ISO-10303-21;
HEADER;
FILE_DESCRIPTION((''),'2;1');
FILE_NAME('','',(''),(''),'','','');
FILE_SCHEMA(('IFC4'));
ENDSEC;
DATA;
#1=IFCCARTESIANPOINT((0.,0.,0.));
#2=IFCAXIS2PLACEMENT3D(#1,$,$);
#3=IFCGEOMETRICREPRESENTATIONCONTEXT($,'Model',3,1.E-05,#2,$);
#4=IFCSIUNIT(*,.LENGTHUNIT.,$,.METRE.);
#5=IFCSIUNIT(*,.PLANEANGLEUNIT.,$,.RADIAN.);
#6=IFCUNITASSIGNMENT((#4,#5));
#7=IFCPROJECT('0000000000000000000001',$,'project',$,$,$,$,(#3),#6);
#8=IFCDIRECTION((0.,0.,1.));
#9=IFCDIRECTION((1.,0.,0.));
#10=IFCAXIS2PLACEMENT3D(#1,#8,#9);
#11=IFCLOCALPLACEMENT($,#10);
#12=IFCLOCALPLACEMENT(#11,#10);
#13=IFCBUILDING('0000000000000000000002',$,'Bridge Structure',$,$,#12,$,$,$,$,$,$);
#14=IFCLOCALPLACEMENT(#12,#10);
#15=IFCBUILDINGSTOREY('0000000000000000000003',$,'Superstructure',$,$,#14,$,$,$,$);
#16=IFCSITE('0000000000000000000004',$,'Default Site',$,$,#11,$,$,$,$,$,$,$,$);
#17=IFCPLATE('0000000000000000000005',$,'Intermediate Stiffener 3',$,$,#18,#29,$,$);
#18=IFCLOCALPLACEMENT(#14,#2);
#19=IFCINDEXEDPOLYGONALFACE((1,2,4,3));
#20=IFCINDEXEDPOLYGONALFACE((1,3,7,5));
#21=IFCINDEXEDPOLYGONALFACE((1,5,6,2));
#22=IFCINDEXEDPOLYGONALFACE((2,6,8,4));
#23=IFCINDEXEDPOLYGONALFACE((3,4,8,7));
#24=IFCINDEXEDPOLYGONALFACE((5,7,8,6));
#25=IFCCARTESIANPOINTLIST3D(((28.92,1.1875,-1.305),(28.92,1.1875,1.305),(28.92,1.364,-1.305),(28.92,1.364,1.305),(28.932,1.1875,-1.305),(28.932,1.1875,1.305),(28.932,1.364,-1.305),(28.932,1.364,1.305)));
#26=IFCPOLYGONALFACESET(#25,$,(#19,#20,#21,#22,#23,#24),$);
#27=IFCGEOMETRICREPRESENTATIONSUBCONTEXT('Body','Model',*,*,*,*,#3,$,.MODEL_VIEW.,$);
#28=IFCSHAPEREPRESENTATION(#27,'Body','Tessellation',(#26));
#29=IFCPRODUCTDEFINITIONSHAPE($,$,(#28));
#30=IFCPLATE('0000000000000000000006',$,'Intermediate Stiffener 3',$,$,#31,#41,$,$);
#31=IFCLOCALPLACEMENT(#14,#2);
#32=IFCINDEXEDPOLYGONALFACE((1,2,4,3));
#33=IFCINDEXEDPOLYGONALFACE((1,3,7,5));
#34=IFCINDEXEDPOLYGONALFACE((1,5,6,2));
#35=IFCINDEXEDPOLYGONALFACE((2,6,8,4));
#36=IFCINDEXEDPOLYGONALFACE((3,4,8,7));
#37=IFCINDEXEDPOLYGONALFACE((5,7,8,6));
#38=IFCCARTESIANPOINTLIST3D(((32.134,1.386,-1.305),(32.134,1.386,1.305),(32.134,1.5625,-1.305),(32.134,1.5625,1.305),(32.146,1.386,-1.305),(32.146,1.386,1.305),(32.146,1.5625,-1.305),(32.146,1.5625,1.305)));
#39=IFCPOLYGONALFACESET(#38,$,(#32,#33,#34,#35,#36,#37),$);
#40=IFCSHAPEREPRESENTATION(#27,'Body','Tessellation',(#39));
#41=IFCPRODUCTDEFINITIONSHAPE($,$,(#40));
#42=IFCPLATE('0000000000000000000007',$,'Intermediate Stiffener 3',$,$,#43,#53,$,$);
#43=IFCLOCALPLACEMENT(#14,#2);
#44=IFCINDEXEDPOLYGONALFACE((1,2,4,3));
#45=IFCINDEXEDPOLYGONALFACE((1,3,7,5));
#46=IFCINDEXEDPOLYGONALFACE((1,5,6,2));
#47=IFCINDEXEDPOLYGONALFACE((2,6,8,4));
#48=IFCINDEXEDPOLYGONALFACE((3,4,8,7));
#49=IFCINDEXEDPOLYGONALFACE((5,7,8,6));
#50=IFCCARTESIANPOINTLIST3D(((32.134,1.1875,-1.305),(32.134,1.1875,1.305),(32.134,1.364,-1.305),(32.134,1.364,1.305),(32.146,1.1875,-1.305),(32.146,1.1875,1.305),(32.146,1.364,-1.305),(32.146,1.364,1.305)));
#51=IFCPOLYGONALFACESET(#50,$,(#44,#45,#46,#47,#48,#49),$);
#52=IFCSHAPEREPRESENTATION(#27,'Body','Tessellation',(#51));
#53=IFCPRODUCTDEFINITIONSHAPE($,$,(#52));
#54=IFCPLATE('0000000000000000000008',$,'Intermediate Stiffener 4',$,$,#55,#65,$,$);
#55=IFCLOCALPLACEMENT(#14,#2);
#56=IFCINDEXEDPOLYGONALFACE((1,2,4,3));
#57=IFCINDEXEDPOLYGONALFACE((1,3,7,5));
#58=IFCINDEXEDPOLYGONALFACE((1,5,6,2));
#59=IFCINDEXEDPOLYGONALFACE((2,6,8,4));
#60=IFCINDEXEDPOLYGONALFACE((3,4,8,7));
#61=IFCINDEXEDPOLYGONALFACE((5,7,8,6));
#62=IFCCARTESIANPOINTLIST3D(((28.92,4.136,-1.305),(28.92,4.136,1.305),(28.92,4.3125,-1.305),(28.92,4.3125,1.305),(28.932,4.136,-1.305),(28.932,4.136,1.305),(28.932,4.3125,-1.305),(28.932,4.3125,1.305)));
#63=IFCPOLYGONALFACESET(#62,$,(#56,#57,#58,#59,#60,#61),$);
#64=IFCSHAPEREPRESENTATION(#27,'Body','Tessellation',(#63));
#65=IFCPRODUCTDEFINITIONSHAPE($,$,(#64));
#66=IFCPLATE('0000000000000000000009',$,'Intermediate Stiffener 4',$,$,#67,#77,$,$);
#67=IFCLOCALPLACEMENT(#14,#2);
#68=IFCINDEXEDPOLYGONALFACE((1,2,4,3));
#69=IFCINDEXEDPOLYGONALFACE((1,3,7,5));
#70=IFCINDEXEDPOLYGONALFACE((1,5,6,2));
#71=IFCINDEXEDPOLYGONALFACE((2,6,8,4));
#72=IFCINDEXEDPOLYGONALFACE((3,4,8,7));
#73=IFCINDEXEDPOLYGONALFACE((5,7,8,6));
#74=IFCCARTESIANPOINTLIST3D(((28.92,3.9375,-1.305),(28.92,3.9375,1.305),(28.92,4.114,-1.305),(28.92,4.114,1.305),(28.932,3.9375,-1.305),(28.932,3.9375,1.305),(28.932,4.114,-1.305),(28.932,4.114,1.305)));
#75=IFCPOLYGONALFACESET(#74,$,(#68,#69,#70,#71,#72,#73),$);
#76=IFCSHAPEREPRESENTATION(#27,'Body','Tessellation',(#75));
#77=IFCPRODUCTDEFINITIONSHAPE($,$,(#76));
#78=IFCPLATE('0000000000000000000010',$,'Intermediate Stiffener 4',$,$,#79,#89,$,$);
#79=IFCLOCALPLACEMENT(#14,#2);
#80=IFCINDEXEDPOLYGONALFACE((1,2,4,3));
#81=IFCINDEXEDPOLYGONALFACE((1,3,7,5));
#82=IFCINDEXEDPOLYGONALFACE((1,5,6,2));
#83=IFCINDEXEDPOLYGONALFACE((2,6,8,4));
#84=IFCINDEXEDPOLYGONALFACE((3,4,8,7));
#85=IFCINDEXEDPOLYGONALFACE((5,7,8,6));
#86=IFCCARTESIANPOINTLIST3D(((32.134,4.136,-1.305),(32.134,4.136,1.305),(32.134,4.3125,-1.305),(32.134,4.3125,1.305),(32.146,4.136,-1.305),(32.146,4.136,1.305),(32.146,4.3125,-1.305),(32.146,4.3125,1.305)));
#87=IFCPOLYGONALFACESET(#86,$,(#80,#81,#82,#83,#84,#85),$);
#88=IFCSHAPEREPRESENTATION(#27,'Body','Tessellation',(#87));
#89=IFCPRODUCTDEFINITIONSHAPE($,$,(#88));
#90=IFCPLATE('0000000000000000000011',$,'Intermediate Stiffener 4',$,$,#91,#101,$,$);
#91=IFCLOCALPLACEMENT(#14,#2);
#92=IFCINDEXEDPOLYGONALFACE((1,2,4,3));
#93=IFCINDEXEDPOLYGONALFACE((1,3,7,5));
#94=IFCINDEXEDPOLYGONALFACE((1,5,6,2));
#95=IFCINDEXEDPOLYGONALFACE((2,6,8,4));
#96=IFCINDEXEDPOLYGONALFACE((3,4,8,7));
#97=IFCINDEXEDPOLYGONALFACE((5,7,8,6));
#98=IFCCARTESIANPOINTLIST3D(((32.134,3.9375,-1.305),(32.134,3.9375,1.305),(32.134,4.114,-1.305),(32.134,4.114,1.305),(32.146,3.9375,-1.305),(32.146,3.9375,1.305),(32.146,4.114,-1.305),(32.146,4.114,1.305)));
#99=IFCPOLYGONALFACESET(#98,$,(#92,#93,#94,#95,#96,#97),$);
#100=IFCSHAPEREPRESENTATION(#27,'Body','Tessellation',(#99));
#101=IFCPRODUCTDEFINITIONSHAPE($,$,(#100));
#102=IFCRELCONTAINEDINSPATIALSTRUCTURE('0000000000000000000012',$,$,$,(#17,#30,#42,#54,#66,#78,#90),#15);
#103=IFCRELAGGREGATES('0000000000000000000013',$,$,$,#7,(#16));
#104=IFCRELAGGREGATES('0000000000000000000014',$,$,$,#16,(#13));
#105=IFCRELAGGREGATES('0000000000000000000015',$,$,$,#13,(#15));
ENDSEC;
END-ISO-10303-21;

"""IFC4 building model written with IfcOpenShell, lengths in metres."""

from ifc_helpers import new_model, si_unit, frame, origin, origin_with_axes, origin_2d_with_axis, place, context, subcontext, project, spatial, rectangle, extrude, element, save


model = new_model("IFC4")

# Units and contexts
model_context = context("Model", 3, precision=1e-05, world=origin())
body_context = subcontext(model_context, "Body", "Model", "MODEL_VIEW")
ifc_project = project(units=[si_unit("LENGTHUNIT", "METRE"), si_unit("PLANEANGLEUNIT", "RADIAN")], contexts=[model_context])

# Site, building, storey
site_placement = place(None, origin_with_axes())
site = spatial("IfcSite", under=ifc_project, at=site_placement, Name="Default Site")
building_placement = place(site_placement, origin_with_axes())
building = spatial("IfcBuilding", under=site, at=building_placement, Name="Bridge Structure")
storey_placement = place(building_placement, origin_with_axes())
storey = spatial("IfcBuildingStorey", under=building, at=storey_placement, Name="Superstructure")

# Plates
for number, where, z_axis, x_axis, name in (
    (1, (28.926, 1.2757, -1.305), (0.0, 0.0, 1.0), (1.0, 0.0, 0.0), "Intermediate Stiffener 3"),
    (2, (32.14, 1.4743, -1.305), (0.0, 0.0, 1.0), (1.0, 0.0, 0.0), "Intermediate Stiffener 3"),
    (3, (32.14, 1.2757, -1.305), (0.0, 0.0, 1.0), (1.0, 0.0, 0.0), "Intermediate Stiffener 3"),
    (4, (28.926, 4.2243, -1.305), (0.0, 0.0, 1.0), (1.0, 0.0, 0.0), "Intermediate Stiffener 4"),
    (5, (28.926, 4.0258, -1.305), (0.0, 0.0, 1.0), (1.0, 0.0, 0.0), "Intermediate Stiffener 4"),
    (6, (32.14, 4.2243, -1.305), (0.0, 0.0, 1.0), (1.0, 0.0, 0.0), "Intermediate Stiffener 4"),
    (7, (32.14, 4.0258, -1.305), (0.0, 0.0, 1.0), (1.0, 0.0, 0.0), "Intermediate Stiffener 4"),
):
    element("IfcPlate", number, at=place(storey_placement, frame(where, z_axis=z_axis, x_axis=x_axis)), inside=storey, Name=name, context=body_context, shape_type="SweptSolid", body=[
        extrude(rectangle(XDim=0.012, YDim=0.1765, at=origin_2d_with_axis()), origin_with_axes(), (0.0, 0.0, 1.0), 2.61),
    ])

save(model, "model.ifc")
